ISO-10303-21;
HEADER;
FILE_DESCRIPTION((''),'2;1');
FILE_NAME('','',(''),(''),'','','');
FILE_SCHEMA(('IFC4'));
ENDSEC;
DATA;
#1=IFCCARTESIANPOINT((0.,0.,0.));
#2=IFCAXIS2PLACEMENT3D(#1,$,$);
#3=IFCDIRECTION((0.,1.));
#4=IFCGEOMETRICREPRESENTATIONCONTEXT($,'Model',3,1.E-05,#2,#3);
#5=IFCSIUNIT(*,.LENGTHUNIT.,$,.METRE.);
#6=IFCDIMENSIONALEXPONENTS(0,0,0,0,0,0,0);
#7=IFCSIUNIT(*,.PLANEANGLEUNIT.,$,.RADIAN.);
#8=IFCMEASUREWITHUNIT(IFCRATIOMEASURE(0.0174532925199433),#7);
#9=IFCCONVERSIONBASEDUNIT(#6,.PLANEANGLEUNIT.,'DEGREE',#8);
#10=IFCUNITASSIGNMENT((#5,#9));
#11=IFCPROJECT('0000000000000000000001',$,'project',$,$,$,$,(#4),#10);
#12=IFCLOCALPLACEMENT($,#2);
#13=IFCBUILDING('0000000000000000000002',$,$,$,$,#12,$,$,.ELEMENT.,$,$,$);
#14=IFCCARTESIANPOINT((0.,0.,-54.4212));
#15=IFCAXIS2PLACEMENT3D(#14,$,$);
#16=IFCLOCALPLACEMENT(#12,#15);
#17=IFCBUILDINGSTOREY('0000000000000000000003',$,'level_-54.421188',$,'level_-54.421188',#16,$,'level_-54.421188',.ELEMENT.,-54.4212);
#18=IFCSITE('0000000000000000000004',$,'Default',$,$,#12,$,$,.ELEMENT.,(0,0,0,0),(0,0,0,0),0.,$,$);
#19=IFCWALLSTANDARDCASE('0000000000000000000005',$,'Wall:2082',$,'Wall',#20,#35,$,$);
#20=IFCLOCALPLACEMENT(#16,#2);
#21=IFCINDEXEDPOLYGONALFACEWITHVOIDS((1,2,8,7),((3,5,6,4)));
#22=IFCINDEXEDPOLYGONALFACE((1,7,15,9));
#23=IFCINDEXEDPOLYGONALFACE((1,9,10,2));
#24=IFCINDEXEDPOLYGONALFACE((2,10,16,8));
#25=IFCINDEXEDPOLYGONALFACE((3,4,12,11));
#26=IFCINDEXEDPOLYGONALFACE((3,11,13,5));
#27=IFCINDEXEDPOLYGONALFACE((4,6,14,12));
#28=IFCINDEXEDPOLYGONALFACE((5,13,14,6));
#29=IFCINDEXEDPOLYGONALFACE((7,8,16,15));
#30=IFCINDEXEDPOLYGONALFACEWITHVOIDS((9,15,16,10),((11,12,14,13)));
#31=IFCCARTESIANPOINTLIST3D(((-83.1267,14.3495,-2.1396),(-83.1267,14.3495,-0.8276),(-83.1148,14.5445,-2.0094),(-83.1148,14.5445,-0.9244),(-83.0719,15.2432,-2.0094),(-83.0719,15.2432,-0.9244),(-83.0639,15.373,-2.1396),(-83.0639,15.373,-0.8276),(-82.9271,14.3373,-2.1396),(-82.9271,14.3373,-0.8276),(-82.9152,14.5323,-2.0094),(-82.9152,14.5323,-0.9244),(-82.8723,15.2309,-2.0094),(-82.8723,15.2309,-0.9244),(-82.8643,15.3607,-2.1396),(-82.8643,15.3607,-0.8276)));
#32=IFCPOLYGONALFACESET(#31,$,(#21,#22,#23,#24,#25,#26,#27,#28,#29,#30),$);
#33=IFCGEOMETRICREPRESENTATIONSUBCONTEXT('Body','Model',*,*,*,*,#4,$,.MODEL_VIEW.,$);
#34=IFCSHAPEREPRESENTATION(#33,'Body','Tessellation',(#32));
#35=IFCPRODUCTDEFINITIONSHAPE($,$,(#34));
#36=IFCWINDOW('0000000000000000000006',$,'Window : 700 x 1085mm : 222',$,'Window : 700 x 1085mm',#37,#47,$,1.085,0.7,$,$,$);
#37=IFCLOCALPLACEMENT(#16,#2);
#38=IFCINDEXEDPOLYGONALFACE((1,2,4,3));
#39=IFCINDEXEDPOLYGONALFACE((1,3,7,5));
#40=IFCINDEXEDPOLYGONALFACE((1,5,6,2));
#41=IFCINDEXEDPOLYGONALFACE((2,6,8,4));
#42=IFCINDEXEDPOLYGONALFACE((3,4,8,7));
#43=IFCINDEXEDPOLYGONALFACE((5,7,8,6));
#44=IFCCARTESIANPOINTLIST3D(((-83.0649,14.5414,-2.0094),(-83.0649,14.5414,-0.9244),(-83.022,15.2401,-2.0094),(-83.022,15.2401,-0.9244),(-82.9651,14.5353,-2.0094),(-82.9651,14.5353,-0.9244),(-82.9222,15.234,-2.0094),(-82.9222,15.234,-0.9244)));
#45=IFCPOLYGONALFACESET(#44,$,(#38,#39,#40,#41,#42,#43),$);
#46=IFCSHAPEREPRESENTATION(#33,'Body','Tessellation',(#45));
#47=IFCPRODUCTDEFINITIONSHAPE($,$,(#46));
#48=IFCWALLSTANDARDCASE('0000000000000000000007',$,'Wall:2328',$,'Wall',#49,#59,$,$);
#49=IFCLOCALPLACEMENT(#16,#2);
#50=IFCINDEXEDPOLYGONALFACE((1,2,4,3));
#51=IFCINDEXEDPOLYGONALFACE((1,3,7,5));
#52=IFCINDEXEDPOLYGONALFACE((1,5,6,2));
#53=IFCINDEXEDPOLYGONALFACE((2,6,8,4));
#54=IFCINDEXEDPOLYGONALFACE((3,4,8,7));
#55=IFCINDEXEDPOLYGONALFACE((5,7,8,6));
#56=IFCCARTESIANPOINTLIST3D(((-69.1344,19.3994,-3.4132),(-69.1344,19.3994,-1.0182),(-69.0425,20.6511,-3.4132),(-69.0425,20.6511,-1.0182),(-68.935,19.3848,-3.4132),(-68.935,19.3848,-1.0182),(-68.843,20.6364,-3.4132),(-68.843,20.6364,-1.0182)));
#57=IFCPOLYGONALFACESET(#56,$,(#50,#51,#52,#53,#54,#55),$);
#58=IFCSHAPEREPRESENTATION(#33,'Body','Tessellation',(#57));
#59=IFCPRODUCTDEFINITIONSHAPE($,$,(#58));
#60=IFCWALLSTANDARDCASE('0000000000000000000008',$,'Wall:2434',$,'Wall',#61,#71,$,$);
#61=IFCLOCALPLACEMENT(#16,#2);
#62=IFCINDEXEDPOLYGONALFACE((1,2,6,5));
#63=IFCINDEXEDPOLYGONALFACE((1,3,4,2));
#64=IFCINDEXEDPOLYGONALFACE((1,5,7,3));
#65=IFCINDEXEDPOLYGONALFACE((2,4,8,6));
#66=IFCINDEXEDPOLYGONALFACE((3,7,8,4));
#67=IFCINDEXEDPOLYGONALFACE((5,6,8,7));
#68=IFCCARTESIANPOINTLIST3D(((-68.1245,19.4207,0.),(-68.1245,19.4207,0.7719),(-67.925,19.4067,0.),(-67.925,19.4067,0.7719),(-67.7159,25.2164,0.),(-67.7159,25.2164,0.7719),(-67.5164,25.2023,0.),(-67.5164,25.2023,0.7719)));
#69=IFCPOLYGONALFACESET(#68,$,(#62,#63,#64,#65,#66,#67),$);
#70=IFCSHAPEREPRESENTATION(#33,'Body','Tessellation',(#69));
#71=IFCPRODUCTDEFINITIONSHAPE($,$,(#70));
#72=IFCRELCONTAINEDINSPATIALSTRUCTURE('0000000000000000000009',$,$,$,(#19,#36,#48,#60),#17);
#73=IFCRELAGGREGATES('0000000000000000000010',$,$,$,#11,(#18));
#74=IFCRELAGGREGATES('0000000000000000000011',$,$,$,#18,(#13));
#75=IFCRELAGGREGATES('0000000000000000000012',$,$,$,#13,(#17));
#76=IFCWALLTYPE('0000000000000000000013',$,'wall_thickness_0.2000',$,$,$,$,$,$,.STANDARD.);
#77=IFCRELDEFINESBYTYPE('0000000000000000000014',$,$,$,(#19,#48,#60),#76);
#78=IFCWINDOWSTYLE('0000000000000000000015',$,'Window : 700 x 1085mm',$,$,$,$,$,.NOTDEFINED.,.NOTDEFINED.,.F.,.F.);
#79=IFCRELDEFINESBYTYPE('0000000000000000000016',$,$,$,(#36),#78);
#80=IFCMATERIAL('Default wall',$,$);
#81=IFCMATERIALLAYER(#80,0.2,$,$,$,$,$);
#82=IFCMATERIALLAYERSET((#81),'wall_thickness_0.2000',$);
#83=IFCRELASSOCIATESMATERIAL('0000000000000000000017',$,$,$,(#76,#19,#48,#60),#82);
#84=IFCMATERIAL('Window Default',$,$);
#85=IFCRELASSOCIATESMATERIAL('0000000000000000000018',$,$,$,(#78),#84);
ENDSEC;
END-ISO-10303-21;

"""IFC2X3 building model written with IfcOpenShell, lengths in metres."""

from ifc_helpers import new_model, entity, si_unit, converted_unit, direction, frame, frame_2d, origin, origin_2d_with_axis, place, context, subcontext, project, spatial, polyline, rectangle, outline, extrude, source, transform, mapped, material, layer, layer_set, layer_usage, type_object, type_shapes, element, fill, save


model = new_model("IFC2X3")

# Units and contexts
model_context = context("Model", 3, precision=1e-05, world=origin(), true_north=direction((0.0, 1.0)))
body_context = subcontext(model_context, "Body", "Model", "MODEL_VIEW")
ifc_project = project(units=[si_unit("LENGTHUNIT", "METRE"), converted_unit("PLANEANGLEUNIT", "DEGREE", entity("IfcRatioMeasure", 0.0174532925199433), si_unit("PLANEANGLEUNIT", "RADIAN"), dimensions=[0, 0, 0, 0, 0, 0, 0])], contexts=[model_context])

# Site, building, storey
placement_1 = place(None, origin())
site = spatial("IfcSite", under=ifc_project, at=placement_1, Name="Default", CompositionType="ELEMENT", RefLatitude=(0, 0, 0, 0), RefLongitude=(0, 0, 0, 0), RefElevation=0.0)
building = spatial("IfcBuilding", under=site, at=placement_1, CompositionType="ELEMENT")
storey_placement = place(placement_1, frame((0.0, 0.0, -54.4212)))
storey = spatial("IfcBuildingStorey", under=building, at=storey_placement, Name="level_-54.421188", ObjectType="level_-54.421188", LongName="level_-54.421188", CompositionType="ELEMENT", Elevation=-54.4212)

# Shared definitions
ifc_material_1 = material(Name="Default wall")
ifc_layer = layer(ifc_material_1, 0.2)
ifc_layer_set = layer_set([ifc_layer], Name="wall_thickness_0.2000")
ifc_layer_usage = layer_usage(ifc_layer_set, "AXIS2", "POSITIVE", -0.1)
wall_type = type_object("IfcWallType", Name="wall_thickness_0.2000", PredefinedType="STANDARD", material=ifc_layer_set)

# Shared definitions
ifc_material_2 = material(Name="Window Default")

# Wall, opening, window
placement_2 = place(placement_1, frame((0.0, 0.0, -56.5608)))
wall_1_placement = place(placement_2, frame((-82.9641, 15.3668, 0.0), z_axis=(0.0, 0.0, 1.0), x_axis=(-0.061281, -0.998121, 0.0)))
wall_1 = element("IfcWallStandardCase", 1, at=wall_1_placement, inside=storey, type_object=wall_type, material=ifc_layer_usage, Name="Wall:2082", ObjectType="Wall", context=body_context, shape_type="SweptSolid", body=[
    extrude(outline(polyline([(1.0254, -0.1), (1.0254, 0.1), (0.0, 0.1), (0.0, -0.1), (1.0254, -0.1)])), origin(), (0.0, 0.0, 1.0), 1.312),
])
opening_1_placement = place(wall_1_placement, frame((0.13, -0.1, 0.1302)))
opening_1 = element("IfcOpeningElement", 2, at=opening_1_placement, cuts=wall_1, ObjectType="Opening", context=body_context, shape_type="SweptSolid", body=[
    extrude(rectangle(XDim=0.7, YDim=1.085, at=frame_2d((0.5425, 0.35), x_axis=(0.0, 1.0))), frame((0.0, 0.0, 0.0), z_axis=(0.0, 1.0, 0.0), x_axis=(0.0, 0.0, 1.0)), (0.0, 0.0, 1.0), 0.2),
])
window_style_1 = type_object("IfcWindowStyle", Name="Window : 700 x 1085mm", ConstructionType="NOTDEFINED", OperationType="NOTDEFINED", ParameterTakesPrecedence=False, Sizeable=False, material=ifc_material_2)
shared_shape_1 = source(origin(), body_context, "Body", "SweptSolid", [
    extrude(rectangle(XDim=0.1, YDim=0.7, at=origin_2d_with_axis()), frame((0.35, 0.1, 0.0), z_axis=(0.0, 0.0, 1.0), x_axis=(0.0, 1.0, 0.0)), (0.0, 0.0, 1.0), 1.085),
])
type_shapes(window_style_1, [shared_shape_1])
window_1_placement = place(opening_1_placement, origin())
window_1 = element("IfcWindow", 3, at=window_1_placement, inside=storey, type_object=window_style_1, Name="Window : 700 x 1085mm : 222", ObjectType="Window : 700 x 1085mm", OverallHeight=1.085, OverallWidth=0.7, context=body_context, shape_type="MappedRepresentation", body=[
    mapped(shared_shape_1, transform((0.0, 0.0, 0.0), scale=1.0)),
])
fill(opening_1, window_1)

# Walls
placement_3 = place(placement_1, frame((0.0, 0.0, -57.8344)))
wall_2_placement = place(placement_3, frame((-68.9428, 20.6437, 0.0), z_axis=(0.0, 0.0, 1.0), x_axis=(-0.07326, -0.997313, 0.0)))
element("IfcWallStandardCase", 4, at=wall_2_placement, inside=storey, type_object=wall_type, material=ifc_layer_usage, Name="Wall:2328", ObjectType="Wall", context=body_context, shape_type="SweptSolid", body=[
    extrude(outline(polyline([(1.255, -0.1), (1.255, 0.1), (0.0, 0.1), (0.0, -0.1), (1.255, -0.1)])), origin(), (0.0, 0.0, 1.0), 2.395),
])
wall_3_placement = place(storey_placement, frame((-68.0248, 19.4137, 0.0), z_axis=(0.0, 0.0, 1.0), x_axis=(0.070328, 0.997524, 0.0)))
element("IfcWallStandardCase", 5, at=wall_3_placement, inside=storey, type_object=wall_type, material=ifc_layer_usage, Name="Wall:2434", ObjectType="Wall", context=body_context, shape_type="SweptSolid", body=[
    extrude(outline(polyline([(5.81, -0.1), (5.81, 0.1), (0.0, 0.1), (0.0, -0.1), (5.81, -0.1)])), origin(), (0.0, 0.0, 1.0), 0.7719),
])

save(model, "model.ifc")
